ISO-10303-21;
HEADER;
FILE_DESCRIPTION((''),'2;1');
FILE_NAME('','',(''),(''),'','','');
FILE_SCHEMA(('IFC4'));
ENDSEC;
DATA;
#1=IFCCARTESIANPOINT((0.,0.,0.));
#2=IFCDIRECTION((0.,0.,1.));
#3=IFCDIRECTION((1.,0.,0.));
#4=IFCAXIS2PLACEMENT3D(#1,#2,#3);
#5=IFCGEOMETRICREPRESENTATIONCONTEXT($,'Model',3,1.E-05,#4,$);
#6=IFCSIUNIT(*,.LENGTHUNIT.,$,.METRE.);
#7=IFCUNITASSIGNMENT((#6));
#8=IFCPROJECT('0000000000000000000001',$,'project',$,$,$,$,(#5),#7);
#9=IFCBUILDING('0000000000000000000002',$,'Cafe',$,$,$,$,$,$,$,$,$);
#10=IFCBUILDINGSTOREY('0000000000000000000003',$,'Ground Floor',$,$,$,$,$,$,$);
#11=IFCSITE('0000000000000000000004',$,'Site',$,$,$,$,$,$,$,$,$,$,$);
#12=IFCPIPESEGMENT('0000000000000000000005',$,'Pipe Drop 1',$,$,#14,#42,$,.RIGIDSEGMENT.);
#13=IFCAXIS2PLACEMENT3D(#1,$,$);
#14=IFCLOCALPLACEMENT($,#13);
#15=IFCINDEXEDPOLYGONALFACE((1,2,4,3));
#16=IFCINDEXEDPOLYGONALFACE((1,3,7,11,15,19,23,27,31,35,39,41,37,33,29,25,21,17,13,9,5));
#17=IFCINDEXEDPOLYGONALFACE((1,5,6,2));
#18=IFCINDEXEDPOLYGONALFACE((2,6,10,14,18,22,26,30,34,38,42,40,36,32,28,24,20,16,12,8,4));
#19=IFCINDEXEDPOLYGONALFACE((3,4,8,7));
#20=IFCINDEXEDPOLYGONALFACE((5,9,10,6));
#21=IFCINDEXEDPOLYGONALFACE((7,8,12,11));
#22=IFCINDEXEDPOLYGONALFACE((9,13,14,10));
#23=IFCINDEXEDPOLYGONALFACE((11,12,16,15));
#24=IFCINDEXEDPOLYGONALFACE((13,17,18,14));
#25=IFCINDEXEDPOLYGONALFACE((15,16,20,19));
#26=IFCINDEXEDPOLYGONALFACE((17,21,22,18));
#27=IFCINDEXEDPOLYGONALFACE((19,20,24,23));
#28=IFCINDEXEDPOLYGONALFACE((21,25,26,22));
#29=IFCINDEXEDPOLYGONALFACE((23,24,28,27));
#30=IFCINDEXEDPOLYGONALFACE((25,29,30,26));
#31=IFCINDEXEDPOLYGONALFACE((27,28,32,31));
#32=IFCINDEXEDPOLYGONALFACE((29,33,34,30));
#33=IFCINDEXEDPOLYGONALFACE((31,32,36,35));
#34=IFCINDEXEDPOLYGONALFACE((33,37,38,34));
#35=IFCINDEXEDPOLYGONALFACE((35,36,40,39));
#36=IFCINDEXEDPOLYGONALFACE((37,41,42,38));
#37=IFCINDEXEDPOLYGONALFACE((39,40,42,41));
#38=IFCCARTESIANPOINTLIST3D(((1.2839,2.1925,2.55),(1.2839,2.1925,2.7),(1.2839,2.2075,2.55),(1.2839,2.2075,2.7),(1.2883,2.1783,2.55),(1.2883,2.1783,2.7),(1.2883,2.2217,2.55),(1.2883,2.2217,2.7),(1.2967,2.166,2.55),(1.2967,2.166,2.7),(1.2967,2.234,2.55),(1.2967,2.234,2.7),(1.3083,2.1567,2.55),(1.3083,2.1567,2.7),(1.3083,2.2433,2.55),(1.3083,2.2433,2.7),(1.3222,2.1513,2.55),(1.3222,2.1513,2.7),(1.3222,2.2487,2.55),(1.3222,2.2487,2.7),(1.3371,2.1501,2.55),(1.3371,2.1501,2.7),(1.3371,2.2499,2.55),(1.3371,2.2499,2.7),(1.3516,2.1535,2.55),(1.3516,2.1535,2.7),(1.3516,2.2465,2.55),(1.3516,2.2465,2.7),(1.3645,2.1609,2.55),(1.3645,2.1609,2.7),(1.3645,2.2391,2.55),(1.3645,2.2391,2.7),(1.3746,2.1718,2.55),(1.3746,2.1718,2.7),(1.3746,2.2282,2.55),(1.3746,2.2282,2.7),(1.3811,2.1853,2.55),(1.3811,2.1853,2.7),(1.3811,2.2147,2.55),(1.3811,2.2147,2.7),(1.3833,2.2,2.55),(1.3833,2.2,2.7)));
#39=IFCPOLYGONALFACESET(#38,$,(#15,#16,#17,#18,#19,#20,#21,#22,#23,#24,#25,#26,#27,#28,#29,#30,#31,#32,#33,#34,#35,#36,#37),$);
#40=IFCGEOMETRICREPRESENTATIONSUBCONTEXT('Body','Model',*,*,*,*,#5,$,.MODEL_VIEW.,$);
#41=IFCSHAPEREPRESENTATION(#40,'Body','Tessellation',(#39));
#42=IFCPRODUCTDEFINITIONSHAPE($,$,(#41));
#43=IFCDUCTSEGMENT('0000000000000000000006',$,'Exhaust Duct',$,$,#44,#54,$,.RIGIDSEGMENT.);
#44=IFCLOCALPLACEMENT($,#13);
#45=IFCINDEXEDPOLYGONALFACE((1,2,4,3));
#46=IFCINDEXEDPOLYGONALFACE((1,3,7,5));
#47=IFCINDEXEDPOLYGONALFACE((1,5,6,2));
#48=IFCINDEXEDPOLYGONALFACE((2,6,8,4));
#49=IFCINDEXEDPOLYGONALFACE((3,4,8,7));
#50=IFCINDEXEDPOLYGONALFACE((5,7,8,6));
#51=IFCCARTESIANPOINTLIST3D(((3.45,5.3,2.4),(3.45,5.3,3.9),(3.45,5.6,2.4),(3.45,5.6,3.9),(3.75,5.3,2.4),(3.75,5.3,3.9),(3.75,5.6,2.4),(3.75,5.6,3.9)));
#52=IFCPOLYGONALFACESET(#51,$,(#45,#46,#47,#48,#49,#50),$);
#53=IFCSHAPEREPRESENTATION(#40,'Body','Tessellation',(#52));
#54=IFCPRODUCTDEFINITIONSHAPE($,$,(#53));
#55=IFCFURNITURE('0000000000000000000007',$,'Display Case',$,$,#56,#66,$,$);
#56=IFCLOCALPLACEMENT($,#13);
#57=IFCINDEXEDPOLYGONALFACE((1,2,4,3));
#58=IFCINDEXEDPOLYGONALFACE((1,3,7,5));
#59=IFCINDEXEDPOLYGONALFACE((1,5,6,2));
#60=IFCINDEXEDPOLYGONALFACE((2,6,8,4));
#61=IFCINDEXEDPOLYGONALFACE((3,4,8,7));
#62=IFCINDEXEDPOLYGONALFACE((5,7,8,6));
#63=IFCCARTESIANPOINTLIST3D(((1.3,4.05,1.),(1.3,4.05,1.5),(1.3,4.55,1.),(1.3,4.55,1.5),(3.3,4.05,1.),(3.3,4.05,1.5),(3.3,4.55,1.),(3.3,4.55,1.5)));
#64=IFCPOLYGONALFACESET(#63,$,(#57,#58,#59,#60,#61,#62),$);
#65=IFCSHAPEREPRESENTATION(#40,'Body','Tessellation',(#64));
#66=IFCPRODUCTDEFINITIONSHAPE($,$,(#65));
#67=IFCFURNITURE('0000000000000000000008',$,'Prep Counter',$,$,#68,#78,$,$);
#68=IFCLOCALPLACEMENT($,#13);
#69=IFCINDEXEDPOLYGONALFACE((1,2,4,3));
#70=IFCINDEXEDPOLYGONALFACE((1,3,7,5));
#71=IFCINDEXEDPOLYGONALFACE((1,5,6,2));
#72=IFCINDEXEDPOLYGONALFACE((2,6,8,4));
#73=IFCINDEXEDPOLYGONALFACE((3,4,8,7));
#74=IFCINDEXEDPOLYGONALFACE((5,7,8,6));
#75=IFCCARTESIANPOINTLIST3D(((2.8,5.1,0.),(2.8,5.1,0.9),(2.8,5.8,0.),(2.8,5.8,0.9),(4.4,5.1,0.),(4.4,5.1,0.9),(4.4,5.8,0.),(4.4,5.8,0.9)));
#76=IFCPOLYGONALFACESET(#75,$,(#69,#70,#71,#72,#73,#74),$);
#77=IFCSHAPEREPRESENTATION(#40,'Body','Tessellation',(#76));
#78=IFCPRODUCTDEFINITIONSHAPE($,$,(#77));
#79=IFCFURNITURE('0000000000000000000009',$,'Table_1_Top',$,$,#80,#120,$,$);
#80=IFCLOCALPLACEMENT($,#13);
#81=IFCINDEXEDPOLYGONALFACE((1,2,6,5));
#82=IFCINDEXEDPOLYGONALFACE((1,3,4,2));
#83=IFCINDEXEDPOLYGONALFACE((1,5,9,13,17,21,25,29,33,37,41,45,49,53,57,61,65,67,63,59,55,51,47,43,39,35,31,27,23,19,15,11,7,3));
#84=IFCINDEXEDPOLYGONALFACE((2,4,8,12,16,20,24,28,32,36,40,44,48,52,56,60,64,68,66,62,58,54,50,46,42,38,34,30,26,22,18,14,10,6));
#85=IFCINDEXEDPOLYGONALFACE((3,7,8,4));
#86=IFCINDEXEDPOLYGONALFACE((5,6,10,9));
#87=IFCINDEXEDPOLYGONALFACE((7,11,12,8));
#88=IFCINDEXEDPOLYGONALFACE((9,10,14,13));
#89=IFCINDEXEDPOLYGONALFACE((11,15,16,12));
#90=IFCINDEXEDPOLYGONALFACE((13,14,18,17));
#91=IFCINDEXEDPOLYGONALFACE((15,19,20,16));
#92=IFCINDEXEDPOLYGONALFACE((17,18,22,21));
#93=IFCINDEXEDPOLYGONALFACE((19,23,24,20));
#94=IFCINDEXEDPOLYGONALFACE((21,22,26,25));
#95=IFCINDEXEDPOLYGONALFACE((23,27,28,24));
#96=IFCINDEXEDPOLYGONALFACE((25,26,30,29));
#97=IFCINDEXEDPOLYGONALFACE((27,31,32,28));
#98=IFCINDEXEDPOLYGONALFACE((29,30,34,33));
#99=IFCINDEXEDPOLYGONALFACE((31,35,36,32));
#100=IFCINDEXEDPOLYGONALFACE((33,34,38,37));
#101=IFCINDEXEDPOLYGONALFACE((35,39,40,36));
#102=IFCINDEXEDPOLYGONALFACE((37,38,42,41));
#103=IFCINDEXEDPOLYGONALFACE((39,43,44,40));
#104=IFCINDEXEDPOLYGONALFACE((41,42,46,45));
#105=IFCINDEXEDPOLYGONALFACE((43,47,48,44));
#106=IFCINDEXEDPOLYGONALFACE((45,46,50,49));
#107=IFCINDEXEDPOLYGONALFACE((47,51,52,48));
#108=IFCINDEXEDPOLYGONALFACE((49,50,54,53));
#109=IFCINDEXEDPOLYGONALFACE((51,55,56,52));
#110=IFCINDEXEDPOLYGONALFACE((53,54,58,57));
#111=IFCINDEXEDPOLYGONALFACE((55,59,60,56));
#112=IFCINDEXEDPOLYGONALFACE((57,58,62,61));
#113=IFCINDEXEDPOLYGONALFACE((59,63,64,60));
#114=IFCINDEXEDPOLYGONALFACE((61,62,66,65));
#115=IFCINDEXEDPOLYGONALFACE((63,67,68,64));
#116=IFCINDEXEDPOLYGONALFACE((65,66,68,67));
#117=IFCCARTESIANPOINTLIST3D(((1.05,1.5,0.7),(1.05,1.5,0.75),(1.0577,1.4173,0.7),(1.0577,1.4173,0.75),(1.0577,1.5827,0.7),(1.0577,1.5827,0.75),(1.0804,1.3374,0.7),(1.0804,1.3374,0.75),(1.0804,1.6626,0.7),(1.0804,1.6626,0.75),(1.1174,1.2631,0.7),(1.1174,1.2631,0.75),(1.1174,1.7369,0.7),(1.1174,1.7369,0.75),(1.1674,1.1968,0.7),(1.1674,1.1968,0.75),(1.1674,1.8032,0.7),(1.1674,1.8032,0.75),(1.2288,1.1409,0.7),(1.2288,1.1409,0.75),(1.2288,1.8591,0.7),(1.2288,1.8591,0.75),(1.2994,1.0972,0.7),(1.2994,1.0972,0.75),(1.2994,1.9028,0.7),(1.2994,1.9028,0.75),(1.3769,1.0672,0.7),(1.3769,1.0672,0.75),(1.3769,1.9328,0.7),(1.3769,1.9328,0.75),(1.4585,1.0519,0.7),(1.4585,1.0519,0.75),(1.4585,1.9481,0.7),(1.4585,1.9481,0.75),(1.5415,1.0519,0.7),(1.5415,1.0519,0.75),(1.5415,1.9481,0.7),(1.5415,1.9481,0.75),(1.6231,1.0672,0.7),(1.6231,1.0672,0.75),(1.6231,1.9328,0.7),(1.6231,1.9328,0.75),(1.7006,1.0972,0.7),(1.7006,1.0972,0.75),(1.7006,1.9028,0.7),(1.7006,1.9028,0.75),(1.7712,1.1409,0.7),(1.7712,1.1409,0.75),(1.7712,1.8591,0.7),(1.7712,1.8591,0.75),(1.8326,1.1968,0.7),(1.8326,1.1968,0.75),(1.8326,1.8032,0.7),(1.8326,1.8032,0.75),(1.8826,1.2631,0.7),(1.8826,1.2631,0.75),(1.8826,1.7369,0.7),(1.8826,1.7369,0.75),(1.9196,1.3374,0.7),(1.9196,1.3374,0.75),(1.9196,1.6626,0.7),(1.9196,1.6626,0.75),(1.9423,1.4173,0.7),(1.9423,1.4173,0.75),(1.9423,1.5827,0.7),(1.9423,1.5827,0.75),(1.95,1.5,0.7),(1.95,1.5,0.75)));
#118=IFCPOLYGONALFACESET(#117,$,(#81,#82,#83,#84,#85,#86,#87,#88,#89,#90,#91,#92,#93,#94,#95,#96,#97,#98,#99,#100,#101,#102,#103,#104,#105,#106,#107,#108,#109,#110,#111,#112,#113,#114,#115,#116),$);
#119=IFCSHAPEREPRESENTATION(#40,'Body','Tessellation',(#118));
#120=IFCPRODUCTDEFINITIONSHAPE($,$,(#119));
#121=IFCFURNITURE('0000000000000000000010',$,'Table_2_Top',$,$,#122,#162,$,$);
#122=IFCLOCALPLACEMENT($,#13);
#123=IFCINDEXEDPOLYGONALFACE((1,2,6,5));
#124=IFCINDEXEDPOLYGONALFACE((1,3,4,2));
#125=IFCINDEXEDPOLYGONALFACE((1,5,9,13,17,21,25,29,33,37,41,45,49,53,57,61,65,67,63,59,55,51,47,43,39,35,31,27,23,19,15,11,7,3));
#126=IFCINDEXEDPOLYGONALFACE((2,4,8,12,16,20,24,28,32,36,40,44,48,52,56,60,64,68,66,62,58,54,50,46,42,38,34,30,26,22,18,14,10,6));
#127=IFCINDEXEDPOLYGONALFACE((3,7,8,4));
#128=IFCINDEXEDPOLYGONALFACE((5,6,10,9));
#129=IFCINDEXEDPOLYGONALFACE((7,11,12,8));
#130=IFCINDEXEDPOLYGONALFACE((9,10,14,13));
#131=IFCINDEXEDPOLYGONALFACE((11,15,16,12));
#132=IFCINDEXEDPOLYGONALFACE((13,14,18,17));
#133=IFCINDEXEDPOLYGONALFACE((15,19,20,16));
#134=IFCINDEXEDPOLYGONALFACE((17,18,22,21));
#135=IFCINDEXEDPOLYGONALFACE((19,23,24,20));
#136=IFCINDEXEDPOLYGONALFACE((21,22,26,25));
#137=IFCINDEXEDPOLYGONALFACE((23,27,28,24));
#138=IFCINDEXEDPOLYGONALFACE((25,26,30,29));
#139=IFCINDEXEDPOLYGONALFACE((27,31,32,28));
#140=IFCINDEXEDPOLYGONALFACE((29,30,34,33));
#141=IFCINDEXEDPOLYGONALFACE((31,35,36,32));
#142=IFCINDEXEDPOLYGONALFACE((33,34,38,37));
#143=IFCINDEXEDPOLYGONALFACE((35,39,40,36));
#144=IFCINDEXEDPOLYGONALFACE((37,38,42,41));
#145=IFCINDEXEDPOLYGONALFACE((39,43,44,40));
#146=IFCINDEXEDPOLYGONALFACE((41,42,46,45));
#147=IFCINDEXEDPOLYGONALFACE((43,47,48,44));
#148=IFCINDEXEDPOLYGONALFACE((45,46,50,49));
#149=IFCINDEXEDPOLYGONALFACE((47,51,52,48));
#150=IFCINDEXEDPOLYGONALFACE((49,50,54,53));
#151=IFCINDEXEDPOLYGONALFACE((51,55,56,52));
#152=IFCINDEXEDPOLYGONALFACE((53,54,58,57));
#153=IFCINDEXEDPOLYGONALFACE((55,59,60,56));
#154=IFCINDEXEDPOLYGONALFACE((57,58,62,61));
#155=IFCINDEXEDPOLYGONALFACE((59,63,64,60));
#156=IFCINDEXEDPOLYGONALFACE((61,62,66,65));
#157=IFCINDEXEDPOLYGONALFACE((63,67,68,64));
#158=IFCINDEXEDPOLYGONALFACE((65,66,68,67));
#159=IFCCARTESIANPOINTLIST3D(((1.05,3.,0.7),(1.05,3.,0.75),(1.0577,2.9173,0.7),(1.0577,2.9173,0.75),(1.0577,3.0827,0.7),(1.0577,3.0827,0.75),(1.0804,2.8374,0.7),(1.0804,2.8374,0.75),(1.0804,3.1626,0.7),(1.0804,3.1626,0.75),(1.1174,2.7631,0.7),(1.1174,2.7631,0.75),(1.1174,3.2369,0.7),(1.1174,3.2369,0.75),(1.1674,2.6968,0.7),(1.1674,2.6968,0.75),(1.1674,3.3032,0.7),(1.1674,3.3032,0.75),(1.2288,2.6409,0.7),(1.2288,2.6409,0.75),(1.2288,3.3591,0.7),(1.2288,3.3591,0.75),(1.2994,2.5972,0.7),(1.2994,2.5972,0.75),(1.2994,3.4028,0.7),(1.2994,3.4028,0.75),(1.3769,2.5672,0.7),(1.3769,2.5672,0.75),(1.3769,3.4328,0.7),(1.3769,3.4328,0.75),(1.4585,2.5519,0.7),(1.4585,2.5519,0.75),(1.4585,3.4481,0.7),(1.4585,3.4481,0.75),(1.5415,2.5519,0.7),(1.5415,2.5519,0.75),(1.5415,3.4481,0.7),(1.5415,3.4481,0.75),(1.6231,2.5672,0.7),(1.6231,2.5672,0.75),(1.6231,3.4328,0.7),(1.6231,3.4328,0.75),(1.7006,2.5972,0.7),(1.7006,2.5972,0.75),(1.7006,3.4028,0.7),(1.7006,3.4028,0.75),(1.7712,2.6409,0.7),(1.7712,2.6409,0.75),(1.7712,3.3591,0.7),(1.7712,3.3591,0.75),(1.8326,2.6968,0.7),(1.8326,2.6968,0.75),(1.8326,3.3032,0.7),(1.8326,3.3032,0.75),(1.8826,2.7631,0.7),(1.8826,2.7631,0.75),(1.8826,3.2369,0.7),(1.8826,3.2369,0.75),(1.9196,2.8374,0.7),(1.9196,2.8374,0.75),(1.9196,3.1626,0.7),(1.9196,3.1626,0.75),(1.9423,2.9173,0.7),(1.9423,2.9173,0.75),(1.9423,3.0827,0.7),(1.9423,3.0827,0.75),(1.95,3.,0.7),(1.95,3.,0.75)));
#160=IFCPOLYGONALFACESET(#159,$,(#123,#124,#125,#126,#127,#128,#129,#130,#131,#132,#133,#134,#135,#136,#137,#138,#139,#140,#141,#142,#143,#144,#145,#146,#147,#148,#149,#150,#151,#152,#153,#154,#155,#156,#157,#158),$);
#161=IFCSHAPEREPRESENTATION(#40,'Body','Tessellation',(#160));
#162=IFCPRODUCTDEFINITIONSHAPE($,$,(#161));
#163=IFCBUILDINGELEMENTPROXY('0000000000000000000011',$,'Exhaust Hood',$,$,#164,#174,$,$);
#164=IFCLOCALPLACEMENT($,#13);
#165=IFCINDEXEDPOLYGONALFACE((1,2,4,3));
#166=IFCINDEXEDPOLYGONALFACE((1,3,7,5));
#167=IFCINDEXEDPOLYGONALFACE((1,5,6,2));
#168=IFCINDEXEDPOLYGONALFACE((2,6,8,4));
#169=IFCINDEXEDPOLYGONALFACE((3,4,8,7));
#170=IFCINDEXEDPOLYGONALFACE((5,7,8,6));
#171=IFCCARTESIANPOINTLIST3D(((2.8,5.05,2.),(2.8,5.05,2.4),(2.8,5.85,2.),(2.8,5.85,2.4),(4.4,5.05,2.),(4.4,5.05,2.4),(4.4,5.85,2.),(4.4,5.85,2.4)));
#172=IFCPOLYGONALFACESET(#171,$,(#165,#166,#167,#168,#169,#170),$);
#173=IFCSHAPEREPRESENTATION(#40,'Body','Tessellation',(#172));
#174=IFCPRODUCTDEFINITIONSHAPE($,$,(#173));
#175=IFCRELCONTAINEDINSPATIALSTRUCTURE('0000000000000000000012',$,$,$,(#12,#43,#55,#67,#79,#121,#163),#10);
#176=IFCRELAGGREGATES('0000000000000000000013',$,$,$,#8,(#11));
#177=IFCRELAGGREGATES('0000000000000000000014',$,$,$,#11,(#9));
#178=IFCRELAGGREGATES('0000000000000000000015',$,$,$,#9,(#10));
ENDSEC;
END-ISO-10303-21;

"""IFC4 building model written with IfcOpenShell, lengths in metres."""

from ifc_helpers import new_model, si_unit, frame, origin, origin_with_axes, origin_2d, place, context, subcontext, project, spatial, rectangle, circle, extrude, element, save


model = new_model("IFC4")

# Units and contexts
model_context = context("Model", 3, precision=1e-05, world=origin_with_axes())
body_context = subcontext(model_context, "Body", "Model", "MODEL_VIEW")
ifc_project = project(units=[si_unit("LENGTHUNIT", "METRE")], contexts=[model_context])

# Site, building, storey
site = spatial("IfcSite", under=ifc_project, Name="Site")
building = spatial("IfcBuilding", under=site, Name="Cafe")
storey = spatial("IfcBuildingStorey", under=building, Name="Ground Floor")

# Pipe segment
pipe_segment_1_placement = place(None, frame((1.3333, 2.2, 2.55), z_axis=(0.0, 0.0, 1.0), x_axis=(1.0, 0.0, 0.0)))
element("IfcPipeSegment", 1, at=pipe_segment_1_placement, inside=storey, Name="Pipe Drop 1", PredefinedType="RIGIDSEGMENT", context=body_context, shape_type="SweptSolid", body=[
    extrude(circle(Radius=0.05, at=origin_2d()), origin(), (0.0, 0.0, 1.0), 0.15),
])

# Duct segment
duct_segment_placement = place(None, frame((3.6, 5.45, 2.4), z_axis=(0.0, 0.0, 1.0), x_axis=(1.0, 0.0, 0.0)))
element("IfcDuctSegment", 2, at=duct_segment_placement, inside=storey, Name="Exhaust Duct", PredefinedType="RIGIDSEGMENT", context=body_context, shape_type="SweptSolid", body=[
    extrude(rectangle(XDim=0.3, YDim=0.3, at=origin_2d()), origin(), (0.0, 0.0, 1.0), 1.5),
])

# Furniture
furniture_1_placement = place(None, frame((2.3, 4.3, 1.0), z_axis=(0.0, 0.0, 1.0), x_axis=(1.0, 0.0, 0.0)))
element("IfcFurniture", 3, at=furniture_1_placement, inside=storey, Name="Display Case", context=body_context, shape_type="SweptSolid", body=[
    extrude(rectangle(XDim=2.0, YDim=0.5, at=origin_2d()), origin(), (0.0, 0.0, 1.0), 0.5),
])
furniture_2_placement = place(None, frame((3.6, 5.45, 0.0), z_axis=(0.0, 0.0, 1.0), x_axis=(1.0, 0.0, 0.0)))
element("IfcFurniture", 4, at=furniture_2_placement, inside=storey, Name="Prep Counter", context=body_context, shape_type="SweptSolid", body=[
    extrude(rectangle(XDim=1.6, YDim=0.7, at=origin_2d()), origin(), (0.0, 0.0, 1.0), 0.9),
])
for number, where, z_axis, x_axis, name in (
    (5, (1.5, 1.5, 0.7), (0.0, 0.0, 1.0), (1.0, 0.0, 0.0), "Table_1_Top"),
    (6, (1.5, 3.0, 0.7), (0.0, 0.0, 1.0), (1.0, 0.0, 0.0), "Table_2_Top"),
):
    element("IfcFurniture", number, at=place(None, frame(where, z_axis=z_axis, x_axis=x_axis)), inside=storey, Name=name, context=body_context, shape_type="SweptSolid", body=[
        extrude(circle(Radius=0.45, at=origin_2d()), origin(), (0.0, 0.0, 1.0), 0.05),
    ])

# Building element proxy
proxy_placement = place(None, frame((3.6, 5.45, 2.0), z_axis=(0.0, 0.0, 1.0), x_axis=(1.0, 0.0, 0.0)))
element("IfcBuildingElementProxy", 7, at=proxy_placement, inside=storey, Name="Exhaust Hood", context=body_context, shape_type="SweptSolid", body=[
    extrude(rectangle(XDim=1.6, YDim=0.8, at=origin_2d()), origin(), (0.0, 0.0, 1.0), 0.4),
])

save(model, "model.ifc")
